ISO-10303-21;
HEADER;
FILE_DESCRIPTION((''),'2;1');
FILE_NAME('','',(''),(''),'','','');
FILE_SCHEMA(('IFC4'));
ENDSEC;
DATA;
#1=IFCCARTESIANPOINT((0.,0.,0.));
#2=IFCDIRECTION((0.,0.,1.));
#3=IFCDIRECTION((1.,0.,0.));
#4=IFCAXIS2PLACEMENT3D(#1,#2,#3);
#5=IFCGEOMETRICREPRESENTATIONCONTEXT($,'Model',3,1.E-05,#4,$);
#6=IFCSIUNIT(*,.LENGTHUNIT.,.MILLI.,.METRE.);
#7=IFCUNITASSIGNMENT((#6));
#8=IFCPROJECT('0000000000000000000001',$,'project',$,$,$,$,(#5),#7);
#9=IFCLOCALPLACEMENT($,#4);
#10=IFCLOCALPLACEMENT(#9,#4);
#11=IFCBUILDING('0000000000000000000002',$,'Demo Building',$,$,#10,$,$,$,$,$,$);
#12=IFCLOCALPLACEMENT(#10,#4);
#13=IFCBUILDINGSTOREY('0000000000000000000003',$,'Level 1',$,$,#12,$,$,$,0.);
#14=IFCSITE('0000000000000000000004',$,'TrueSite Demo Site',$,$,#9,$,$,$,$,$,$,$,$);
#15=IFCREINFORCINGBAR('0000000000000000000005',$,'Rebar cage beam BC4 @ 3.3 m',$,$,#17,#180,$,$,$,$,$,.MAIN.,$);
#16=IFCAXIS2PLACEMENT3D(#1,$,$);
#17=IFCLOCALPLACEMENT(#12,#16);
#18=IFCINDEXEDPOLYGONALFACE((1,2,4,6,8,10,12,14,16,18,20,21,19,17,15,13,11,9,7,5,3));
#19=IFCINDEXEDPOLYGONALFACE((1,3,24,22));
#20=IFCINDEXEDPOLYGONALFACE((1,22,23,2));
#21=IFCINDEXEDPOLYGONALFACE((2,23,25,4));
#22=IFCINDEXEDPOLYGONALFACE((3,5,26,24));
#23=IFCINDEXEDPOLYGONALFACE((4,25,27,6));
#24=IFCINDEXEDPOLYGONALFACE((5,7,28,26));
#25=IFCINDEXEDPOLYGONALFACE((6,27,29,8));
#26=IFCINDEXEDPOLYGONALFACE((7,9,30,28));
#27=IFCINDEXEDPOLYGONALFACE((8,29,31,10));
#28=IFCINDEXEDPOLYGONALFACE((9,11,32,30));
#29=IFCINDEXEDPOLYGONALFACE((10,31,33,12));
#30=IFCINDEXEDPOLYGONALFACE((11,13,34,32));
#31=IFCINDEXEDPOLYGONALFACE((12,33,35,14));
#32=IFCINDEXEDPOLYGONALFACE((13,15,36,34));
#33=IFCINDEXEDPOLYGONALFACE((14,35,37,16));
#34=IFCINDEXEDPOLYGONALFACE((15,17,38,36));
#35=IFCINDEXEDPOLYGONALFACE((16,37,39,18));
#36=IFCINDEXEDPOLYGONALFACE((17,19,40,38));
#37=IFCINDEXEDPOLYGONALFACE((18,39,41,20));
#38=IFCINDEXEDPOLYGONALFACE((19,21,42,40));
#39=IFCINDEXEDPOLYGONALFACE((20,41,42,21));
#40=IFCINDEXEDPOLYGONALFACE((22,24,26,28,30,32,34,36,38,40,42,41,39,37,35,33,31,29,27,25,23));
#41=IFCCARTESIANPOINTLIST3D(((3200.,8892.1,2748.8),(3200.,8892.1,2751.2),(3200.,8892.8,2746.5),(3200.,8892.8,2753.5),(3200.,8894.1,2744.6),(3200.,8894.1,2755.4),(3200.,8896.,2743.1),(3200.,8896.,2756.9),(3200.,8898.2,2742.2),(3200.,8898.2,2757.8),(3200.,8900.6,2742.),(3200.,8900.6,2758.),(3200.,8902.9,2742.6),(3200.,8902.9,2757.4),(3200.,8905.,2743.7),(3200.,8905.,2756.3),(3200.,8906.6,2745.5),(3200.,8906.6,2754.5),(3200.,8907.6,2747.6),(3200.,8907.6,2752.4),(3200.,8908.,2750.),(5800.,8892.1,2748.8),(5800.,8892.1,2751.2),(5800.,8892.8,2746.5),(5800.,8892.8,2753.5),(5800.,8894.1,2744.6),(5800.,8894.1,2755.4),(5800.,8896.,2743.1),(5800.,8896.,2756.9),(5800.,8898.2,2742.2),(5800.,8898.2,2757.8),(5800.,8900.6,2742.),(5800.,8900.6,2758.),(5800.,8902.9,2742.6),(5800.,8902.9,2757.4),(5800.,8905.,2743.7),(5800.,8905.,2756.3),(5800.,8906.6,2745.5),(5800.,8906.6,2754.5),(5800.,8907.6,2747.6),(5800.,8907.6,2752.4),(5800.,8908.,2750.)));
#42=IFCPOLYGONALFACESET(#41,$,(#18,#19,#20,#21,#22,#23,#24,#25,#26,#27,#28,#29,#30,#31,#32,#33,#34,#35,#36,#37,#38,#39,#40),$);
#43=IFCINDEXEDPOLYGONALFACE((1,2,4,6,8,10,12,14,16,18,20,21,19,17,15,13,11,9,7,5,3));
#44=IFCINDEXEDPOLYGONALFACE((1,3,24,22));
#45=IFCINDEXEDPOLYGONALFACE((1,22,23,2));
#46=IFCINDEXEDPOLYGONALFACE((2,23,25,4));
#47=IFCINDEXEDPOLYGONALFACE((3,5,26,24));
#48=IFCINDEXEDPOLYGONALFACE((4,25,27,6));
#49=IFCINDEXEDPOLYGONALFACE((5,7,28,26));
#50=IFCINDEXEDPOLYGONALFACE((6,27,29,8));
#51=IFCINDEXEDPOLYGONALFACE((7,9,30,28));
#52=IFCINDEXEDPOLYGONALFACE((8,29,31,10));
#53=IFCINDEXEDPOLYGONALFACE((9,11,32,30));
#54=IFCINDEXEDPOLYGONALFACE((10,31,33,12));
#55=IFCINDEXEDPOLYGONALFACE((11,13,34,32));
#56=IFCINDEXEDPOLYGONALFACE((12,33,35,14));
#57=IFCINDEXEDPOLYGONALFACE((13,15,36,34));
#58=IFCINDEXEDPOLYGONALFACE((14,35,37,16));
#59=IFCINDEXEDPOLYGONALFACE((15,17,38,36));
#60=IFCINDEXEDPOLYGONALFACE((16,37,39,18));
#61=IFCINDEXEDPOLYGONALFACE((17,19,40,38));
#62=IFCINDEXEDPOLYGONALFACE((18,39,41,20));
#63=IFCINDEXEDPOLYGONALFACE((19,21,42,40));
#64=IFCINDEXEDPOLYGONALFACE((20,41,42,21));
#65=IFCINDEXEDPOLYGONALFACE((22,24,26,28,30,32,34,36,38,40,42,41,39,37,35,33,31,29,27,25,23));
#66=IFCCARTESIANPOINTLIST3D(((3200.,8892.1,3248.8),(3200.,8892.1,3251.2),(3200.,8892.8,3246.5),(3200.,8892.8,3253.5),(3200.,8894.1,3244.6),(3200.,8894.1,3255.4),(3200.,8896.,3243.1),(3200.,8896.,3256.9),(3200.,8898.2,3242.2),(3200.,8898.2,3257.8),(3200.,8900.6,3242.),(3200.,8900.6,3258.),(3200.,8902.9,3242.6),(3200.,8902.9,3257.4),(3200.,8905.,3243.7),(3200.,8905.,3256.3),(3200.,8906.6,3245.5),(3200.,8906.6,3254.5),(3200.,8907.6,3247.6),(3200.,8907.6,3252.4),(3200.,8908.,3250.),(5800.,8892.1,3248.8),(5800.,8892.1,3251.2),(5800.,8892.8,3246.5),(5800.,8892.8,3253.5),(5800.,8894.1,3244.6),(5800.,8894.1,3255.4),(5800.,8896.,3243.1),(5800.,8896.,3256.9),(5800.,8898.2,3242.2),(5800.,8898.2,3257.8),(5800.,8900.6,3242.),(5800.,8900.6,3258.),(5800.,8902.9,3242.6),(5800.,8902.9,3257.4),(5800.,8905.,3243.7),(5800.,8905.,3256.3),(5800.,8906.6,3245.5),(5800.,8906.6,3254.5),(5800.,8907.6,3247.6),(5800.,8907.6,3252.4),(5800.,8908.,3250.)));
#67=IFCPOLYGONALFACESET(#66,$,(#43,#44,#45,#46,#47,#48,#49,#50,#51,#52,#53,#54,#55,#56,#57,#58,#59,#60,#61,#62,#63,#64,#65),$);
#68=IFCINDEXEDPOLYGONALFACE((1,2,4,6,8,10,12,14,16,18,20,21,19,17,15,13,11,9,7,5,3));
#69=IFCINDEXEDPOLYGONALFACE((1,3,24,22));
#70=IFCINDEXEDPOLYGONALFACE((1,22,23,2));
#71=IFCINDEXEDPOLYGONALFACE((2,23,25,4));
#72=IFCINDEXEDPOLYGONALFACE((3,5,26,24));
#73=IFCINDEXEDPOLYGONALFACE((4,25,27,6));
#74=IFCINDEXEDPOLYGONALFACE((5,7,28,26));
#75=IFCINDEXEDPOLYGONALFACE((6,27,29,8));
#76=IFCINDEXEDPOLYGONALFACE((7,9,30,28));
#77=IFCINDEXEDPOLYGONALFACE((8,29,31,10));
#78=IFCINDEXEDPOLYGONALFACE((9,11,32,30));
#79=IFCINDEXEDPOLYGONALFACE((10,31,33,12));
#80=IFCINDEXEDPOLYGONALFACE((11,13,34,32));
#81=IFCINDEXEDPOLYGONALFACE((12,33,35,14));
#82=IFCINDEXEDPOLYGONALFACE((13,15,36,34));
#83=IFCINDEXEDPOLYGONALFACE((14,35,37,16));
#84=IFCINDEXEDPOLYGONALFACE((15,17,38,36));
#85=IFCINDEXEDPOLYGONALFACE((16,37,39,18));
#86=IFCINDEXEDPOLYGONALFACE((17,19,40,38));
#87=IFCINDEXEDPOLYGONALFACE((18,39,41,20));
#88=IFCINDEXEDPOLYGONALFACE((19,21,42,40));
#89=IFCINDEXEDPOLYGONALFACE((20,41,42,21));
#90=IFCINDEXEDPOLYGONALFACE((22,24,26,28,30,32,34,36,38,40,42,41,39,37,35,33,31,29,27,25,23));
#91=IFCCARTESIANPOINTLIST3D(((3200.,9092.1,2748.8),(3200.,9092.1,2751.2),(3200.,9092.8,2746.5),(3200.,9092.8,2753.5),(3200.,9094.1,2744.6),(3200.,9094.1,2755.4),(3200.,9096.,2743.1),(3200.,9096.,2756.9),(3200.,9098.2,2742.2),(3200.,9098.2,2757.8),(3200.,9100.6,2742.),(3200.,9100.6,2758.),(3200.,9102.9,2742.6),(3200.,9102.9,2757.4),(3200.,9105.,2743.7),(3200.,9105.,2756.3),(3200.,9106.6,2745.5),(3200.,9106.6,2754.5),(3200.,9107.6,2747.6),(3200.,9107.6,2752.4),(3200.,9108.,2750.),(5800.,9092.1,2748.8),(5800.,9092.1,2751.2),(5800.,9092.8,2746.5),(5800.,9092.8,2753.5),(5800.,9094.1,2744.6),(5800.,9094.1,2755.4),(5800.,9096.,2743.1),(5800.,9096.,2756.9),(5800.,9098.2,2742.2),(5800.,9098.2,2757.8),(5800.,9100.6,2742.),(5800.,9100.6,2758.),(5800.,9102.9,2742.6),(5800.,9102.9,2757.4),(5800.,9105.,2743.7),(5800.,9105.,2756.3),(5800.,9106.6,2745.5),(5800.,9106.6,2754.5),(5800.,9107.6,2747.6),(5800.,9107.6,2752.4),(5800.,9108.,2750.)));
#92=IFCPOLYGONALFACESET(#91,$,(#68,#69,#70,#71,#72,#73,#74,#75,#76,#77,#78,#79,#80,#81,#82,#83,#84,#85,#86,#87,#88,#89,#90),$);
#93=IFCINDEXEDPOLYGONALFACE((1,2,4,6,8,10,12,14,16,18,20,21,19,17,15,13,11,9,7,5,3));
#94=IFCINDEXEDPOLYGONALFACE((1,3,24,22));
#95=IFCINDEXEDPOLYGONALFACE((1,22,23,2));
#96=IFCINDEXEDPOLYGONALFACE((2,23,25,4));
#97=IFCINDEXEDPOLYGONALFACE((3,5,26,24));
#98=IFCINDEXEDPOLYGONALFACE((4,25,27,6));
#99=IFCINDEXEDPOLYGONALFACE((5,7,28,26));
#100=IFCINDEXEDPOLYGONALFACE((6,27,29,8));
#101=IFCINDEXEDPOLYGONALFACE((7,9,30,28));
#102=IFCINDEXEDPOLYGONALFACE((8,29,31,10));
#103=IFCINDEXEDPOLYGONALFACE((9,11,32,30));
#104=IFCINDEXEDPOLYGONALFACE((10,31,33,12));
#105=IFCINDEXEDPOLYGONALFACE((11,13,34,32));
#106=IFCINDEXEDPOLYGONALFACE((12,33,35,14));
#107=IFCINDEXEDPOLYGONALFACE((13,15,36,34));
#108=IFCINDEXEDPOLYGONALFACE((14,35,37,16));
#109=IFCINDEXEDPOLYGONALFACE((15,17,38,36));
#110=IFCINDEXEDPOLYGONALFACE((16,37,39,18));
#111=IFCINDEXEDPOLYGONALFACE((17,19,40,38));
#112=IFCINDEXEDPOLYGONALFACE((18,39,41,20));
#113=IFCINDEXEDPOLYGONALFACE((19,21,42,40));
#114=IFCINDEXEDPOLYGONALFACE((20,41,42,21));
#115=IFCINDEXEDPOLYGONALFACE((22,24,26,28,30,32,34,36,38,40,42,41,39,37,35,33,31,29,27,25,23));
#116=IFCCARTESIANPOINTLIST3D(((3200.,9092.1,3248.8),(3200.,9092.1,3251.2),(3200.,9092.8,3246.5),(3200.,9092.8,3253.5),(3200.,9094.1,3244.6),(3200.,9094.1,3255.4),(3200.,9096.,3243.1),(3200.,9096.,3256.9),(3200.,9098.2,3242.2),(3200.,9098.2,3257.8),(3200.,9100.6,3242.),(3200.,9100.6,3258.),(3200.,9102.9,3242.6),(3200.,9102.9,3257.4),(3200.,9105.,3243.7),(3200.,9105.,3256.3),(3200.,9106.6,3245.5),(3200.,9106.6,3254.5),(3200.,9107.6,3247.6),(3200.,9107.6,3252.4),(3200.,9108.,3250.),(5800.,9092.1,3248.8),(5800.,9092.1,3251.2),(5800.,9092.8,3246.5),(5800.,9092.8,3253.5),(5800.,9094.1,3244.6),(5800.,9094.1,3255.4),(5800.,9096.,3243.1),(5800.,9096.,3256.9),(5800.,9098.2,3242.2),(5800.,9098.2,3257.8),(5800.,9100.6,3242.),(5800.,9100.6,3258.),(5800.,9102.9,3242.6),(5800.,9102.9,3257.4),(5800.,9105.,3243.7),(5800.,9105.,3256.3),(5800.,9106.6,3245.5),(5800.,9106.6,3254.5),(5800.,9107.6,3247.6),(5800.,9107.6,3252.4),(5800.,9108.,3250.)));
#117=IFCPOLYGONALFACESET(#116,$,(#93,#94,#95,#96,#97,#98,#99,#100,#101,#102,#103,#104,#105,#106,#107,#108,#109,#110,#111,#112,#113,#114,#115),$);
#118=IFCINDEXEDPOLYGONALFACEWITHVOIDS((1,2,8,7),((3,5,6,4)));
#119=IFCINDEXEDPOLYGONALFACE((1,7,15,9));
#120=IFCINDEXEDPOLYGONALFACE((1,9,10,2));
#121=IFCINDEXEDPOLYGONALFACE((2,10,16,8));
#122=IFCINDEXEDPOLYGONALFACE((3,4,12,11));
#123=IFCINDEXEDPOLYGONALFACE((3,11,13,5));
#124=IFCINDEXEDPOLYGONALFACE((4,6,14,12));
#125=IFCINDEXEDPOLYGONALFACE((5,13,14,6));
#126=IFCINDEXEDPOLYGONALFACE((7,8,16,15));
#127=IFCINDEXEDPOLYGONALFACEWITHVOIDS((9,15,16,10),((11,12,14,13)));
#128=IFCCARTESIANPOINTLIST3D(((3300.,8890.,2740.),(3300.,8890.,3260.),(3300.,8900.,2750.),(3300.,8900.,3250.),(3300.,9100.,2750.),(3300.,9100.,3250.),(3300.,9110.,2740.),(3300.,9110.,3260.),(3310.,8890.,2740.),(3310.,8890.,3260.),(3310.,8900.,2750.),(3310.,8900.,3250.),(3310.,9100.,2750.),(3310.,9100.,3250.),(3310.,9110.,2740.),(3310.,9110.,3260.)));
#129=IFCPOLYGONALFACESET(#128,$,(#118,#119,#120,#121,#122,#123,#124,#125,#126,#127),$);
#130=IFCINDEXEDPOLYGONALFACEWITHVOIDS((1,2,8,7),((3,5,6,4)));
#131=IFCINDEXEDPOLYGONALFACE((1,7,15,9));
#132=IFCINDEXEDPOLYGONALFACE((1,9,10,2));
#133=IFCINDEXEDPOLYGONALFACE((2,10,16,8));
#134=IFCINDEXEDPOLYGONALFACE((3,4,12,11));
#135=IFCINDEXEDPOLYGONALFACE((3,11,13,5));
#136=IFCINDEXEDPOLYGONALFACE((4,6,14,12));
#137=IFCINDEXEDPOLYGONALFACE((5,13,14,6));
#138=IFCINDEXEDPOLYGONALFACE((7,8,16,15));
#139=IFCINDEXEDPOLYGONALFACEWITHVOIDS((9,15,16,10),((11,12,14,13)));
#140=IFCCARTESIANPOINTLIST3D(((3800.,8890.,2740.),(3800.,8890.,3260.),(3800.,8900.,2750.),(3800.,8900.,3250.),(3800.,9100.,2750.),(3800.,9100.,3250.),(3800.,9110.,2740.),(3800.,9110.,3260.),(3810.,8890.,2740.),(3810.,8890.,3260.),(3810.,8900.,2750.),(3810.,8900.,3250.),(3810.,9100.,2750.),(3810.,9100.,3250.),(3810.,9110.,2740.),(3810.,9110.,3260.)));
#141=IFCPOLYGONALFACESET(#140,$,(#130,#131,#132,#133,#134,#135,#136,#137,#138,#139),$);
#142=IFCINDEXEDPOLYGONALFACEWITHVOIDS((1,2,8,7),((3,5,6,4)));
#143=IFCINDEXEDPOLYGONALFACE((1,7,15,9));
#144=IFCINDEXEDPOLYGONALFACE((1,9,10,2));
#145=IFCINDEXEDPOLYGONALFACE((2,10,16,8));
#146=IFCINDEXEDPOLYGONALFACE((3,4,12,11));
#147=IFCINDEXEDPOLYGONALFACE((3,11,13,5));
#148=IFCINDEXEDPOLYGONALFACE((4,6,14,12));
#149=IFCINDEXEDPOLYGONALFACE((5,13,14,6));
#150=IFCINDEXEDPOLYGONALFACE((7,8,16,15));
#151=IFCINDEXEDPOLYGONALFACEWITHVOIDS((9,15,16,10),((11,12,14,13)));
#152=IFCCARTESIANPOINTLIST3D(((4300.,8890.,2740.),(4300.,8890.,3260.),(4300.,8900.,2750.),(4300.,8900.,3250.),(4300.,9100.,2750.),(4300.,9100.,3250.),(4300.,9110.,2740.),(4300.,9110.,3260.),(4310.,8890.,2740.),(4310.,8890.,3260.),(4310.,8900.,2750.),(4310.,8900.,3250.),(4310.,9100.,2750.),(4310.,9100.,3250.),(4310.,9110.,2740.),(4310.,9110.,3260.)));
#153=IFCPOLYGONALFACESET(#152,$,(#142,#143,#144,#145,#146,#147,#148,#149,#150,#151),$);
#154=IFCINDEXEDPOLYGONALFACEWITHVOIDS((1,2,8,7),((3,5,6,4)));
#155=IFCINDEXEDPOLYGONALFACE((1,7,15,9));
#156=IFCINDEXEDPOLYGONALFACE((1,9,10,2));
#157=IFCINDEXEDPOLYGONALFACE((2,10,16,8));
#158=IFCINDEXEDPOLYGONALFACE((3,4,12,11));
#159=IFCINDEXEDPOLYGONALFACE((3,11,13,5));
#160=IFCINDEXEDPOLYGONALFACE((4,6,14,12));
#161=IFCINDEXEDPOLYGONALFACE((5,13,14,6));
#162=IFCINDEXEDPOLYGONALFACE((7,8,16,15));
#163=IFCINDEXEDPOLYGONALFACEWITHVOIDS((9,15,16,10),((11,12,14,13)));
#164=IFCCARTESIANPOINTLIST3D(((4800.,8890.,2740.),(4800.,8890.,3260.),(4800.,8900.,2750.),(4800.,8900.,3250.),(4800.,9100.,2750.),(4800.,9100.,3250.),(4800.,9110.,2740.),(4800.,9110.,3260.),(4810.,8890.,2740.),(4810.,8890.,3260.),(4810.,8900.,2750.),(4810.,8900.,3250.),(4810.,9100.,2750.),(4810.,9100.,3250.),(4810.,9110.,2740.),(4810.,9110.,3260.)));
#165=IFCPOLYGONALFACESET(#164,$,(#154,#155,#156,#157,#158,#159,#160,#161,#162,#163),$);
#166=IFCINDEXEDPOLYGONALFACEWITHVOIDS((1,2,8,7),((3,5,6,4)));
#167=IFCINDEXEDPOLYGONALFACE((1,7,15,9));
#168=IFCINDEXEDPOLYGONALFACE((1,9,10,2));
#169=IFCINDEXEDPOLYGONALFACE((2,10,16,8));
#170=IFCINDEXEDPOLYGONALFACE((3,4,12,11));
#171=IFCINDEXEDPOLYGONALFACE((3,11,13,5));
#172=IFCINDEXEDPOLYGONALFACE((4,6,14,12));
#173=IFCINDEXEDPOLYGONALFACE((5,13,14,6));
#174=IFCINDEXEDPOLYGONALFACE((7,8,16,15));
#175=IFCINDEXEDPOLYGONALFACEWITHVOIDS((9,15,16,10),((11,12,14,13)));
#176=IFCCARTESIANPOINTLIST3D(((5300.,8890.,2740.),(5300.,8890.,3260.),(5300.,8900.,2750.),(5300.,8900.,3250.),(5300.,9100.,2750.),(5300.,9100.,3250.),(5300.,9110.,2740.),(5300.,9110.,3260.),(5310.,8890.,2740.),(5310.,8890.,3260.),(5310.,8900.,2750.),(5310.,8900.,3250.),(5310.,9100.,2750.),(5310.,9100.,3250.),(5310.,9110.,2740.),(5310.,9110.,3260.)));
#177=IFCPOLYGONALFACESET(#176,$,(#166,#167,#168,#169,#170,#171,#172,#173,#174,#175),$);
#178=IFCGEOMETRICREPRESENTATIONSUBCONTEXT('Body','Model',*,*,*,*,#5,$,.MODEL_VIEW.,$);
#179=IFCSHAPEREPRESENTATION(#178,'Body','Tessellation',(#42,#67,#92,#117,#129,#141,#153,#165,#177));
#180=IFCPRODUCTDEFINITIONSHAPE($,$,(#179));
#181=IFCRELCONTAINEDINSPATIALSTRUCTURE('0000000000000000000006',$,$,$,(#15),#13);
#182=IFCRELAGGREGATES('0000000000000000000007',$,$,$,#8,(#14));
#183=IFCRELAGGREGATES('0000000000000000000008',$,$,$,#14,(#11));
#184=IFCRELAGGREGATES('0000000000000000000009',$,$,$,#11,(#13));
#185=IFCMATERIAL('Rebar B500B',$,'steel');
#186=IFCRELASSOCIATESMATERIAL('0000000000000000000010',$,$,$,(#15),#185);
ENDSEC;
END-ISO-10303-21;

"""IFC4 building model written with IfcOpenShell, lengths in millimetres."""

from ifc_helpers import new_model, si_unit, frame, origin_with_axes, place, context, subcontext, project, spatial, hollow_rectangle, circle, extrude, material, element, save


model = new_model("IFC4")

# Units and contexts
model_context = context("Model", 3, precision=1e-05, world=origin_with_axes())
body_context = subcontext(model_context, "Body", "Model", "MODEL_VIEW")
ifc_project = project(units=[si_unit("LENGTHUNIT", "METRE", prefix="MILLI")], contexts=[model_context])

# Site, building, storey
site_placement = place(None, origin_with_axes())
site = spatial("IfcSite", under=ifc_project, at=site_placement, Name="TrueSite Demo Site")
building_placement = place(site_placement, origin_with_axes())
building = spatial("IfcBuilding", under=site, at=building_placement, Name="Demo Building")
storey_placement = place(building_placement, origin_with_axes())
storey = spatial("IfcBuildingStorey", under=building, at=storey_placement, Name="Level 1", Elevation=0.0)

# Reinforcing bar
ifc_material_1 = material(Name="Rebar B500B", Category="steel")
for number, where, z_axis, x_axis, name in (
    (1, (3200.0, 9000.0, 3000.0), (1.0, 0.0, 0.0), (0.0, 1.0, 0.0), "Rebar cage beam BC4 @ 3.3 m"),
):
    element("IfcReinforcingBar", number, at=place(storey_placement, frame(where, z_axis=z_axis, x_axis=x_axis)), inside=storey, material=ifc_material_1, Name=name, PredefinedType="MAIN", context=body_context, shape_type="SweptSolid", body=[
        extrude(circle(Radius=8.0), frame((-100.0, -250.0, 0.0)), (0.0, 0.0, 1.0), 2600.0),
        extrude(circle(Radius=8.0), frame((-100.0, 250.0, 0.0)), (0.0, 0.0, 1.0), 2600.0),
        extrude(circle(Radius=8.0), frame((100.0, -250.0, 0.0)), (0.0, 0.0, 1.0), 2600.0),
        extrude(circle(Radius=8.0), frame((100.0, 250.0, 0.0)), (0.0, 0.0, 1.0), 2600.0),
        extrude(hollow_rectangle(XDim=220.0, YDim=520.0, WallThickness=10.0), frame((0.0, 0.0, 100.0)), (0.0, 0.0, 1.0), 10.0),
        extrude(hollow_rectangle(XDim=220.0, YDim=520.0, WallThickness=10.0), frame((0.0, 0.0, 600.0)), (0.0, 0.0, 1.0), 10.0),
        extrude(hollow_rectangle(XDim=220.0, YDim=520.0, WallThickness=10.0), frame((0.0, 0.0, 1100.0)), (0.0, 0.0, 1.0), 10.0),
        extrude(hollow_rectangle(XDim=220.0, YDim=520.0, WallThickness=10.0), frame((0.0, 0.0, 1600.0)), (0.0, 0.0, 1.0), 10.0),
        extrude(hollow_rectangle(XDim=220.0, YDim=520.0, WallThickness=10.0), frame((0.0, 0.0, 2100.0)), (0.0, 0.0, 1.0), 10.0),
    ])

save(model, "model.ifc")
